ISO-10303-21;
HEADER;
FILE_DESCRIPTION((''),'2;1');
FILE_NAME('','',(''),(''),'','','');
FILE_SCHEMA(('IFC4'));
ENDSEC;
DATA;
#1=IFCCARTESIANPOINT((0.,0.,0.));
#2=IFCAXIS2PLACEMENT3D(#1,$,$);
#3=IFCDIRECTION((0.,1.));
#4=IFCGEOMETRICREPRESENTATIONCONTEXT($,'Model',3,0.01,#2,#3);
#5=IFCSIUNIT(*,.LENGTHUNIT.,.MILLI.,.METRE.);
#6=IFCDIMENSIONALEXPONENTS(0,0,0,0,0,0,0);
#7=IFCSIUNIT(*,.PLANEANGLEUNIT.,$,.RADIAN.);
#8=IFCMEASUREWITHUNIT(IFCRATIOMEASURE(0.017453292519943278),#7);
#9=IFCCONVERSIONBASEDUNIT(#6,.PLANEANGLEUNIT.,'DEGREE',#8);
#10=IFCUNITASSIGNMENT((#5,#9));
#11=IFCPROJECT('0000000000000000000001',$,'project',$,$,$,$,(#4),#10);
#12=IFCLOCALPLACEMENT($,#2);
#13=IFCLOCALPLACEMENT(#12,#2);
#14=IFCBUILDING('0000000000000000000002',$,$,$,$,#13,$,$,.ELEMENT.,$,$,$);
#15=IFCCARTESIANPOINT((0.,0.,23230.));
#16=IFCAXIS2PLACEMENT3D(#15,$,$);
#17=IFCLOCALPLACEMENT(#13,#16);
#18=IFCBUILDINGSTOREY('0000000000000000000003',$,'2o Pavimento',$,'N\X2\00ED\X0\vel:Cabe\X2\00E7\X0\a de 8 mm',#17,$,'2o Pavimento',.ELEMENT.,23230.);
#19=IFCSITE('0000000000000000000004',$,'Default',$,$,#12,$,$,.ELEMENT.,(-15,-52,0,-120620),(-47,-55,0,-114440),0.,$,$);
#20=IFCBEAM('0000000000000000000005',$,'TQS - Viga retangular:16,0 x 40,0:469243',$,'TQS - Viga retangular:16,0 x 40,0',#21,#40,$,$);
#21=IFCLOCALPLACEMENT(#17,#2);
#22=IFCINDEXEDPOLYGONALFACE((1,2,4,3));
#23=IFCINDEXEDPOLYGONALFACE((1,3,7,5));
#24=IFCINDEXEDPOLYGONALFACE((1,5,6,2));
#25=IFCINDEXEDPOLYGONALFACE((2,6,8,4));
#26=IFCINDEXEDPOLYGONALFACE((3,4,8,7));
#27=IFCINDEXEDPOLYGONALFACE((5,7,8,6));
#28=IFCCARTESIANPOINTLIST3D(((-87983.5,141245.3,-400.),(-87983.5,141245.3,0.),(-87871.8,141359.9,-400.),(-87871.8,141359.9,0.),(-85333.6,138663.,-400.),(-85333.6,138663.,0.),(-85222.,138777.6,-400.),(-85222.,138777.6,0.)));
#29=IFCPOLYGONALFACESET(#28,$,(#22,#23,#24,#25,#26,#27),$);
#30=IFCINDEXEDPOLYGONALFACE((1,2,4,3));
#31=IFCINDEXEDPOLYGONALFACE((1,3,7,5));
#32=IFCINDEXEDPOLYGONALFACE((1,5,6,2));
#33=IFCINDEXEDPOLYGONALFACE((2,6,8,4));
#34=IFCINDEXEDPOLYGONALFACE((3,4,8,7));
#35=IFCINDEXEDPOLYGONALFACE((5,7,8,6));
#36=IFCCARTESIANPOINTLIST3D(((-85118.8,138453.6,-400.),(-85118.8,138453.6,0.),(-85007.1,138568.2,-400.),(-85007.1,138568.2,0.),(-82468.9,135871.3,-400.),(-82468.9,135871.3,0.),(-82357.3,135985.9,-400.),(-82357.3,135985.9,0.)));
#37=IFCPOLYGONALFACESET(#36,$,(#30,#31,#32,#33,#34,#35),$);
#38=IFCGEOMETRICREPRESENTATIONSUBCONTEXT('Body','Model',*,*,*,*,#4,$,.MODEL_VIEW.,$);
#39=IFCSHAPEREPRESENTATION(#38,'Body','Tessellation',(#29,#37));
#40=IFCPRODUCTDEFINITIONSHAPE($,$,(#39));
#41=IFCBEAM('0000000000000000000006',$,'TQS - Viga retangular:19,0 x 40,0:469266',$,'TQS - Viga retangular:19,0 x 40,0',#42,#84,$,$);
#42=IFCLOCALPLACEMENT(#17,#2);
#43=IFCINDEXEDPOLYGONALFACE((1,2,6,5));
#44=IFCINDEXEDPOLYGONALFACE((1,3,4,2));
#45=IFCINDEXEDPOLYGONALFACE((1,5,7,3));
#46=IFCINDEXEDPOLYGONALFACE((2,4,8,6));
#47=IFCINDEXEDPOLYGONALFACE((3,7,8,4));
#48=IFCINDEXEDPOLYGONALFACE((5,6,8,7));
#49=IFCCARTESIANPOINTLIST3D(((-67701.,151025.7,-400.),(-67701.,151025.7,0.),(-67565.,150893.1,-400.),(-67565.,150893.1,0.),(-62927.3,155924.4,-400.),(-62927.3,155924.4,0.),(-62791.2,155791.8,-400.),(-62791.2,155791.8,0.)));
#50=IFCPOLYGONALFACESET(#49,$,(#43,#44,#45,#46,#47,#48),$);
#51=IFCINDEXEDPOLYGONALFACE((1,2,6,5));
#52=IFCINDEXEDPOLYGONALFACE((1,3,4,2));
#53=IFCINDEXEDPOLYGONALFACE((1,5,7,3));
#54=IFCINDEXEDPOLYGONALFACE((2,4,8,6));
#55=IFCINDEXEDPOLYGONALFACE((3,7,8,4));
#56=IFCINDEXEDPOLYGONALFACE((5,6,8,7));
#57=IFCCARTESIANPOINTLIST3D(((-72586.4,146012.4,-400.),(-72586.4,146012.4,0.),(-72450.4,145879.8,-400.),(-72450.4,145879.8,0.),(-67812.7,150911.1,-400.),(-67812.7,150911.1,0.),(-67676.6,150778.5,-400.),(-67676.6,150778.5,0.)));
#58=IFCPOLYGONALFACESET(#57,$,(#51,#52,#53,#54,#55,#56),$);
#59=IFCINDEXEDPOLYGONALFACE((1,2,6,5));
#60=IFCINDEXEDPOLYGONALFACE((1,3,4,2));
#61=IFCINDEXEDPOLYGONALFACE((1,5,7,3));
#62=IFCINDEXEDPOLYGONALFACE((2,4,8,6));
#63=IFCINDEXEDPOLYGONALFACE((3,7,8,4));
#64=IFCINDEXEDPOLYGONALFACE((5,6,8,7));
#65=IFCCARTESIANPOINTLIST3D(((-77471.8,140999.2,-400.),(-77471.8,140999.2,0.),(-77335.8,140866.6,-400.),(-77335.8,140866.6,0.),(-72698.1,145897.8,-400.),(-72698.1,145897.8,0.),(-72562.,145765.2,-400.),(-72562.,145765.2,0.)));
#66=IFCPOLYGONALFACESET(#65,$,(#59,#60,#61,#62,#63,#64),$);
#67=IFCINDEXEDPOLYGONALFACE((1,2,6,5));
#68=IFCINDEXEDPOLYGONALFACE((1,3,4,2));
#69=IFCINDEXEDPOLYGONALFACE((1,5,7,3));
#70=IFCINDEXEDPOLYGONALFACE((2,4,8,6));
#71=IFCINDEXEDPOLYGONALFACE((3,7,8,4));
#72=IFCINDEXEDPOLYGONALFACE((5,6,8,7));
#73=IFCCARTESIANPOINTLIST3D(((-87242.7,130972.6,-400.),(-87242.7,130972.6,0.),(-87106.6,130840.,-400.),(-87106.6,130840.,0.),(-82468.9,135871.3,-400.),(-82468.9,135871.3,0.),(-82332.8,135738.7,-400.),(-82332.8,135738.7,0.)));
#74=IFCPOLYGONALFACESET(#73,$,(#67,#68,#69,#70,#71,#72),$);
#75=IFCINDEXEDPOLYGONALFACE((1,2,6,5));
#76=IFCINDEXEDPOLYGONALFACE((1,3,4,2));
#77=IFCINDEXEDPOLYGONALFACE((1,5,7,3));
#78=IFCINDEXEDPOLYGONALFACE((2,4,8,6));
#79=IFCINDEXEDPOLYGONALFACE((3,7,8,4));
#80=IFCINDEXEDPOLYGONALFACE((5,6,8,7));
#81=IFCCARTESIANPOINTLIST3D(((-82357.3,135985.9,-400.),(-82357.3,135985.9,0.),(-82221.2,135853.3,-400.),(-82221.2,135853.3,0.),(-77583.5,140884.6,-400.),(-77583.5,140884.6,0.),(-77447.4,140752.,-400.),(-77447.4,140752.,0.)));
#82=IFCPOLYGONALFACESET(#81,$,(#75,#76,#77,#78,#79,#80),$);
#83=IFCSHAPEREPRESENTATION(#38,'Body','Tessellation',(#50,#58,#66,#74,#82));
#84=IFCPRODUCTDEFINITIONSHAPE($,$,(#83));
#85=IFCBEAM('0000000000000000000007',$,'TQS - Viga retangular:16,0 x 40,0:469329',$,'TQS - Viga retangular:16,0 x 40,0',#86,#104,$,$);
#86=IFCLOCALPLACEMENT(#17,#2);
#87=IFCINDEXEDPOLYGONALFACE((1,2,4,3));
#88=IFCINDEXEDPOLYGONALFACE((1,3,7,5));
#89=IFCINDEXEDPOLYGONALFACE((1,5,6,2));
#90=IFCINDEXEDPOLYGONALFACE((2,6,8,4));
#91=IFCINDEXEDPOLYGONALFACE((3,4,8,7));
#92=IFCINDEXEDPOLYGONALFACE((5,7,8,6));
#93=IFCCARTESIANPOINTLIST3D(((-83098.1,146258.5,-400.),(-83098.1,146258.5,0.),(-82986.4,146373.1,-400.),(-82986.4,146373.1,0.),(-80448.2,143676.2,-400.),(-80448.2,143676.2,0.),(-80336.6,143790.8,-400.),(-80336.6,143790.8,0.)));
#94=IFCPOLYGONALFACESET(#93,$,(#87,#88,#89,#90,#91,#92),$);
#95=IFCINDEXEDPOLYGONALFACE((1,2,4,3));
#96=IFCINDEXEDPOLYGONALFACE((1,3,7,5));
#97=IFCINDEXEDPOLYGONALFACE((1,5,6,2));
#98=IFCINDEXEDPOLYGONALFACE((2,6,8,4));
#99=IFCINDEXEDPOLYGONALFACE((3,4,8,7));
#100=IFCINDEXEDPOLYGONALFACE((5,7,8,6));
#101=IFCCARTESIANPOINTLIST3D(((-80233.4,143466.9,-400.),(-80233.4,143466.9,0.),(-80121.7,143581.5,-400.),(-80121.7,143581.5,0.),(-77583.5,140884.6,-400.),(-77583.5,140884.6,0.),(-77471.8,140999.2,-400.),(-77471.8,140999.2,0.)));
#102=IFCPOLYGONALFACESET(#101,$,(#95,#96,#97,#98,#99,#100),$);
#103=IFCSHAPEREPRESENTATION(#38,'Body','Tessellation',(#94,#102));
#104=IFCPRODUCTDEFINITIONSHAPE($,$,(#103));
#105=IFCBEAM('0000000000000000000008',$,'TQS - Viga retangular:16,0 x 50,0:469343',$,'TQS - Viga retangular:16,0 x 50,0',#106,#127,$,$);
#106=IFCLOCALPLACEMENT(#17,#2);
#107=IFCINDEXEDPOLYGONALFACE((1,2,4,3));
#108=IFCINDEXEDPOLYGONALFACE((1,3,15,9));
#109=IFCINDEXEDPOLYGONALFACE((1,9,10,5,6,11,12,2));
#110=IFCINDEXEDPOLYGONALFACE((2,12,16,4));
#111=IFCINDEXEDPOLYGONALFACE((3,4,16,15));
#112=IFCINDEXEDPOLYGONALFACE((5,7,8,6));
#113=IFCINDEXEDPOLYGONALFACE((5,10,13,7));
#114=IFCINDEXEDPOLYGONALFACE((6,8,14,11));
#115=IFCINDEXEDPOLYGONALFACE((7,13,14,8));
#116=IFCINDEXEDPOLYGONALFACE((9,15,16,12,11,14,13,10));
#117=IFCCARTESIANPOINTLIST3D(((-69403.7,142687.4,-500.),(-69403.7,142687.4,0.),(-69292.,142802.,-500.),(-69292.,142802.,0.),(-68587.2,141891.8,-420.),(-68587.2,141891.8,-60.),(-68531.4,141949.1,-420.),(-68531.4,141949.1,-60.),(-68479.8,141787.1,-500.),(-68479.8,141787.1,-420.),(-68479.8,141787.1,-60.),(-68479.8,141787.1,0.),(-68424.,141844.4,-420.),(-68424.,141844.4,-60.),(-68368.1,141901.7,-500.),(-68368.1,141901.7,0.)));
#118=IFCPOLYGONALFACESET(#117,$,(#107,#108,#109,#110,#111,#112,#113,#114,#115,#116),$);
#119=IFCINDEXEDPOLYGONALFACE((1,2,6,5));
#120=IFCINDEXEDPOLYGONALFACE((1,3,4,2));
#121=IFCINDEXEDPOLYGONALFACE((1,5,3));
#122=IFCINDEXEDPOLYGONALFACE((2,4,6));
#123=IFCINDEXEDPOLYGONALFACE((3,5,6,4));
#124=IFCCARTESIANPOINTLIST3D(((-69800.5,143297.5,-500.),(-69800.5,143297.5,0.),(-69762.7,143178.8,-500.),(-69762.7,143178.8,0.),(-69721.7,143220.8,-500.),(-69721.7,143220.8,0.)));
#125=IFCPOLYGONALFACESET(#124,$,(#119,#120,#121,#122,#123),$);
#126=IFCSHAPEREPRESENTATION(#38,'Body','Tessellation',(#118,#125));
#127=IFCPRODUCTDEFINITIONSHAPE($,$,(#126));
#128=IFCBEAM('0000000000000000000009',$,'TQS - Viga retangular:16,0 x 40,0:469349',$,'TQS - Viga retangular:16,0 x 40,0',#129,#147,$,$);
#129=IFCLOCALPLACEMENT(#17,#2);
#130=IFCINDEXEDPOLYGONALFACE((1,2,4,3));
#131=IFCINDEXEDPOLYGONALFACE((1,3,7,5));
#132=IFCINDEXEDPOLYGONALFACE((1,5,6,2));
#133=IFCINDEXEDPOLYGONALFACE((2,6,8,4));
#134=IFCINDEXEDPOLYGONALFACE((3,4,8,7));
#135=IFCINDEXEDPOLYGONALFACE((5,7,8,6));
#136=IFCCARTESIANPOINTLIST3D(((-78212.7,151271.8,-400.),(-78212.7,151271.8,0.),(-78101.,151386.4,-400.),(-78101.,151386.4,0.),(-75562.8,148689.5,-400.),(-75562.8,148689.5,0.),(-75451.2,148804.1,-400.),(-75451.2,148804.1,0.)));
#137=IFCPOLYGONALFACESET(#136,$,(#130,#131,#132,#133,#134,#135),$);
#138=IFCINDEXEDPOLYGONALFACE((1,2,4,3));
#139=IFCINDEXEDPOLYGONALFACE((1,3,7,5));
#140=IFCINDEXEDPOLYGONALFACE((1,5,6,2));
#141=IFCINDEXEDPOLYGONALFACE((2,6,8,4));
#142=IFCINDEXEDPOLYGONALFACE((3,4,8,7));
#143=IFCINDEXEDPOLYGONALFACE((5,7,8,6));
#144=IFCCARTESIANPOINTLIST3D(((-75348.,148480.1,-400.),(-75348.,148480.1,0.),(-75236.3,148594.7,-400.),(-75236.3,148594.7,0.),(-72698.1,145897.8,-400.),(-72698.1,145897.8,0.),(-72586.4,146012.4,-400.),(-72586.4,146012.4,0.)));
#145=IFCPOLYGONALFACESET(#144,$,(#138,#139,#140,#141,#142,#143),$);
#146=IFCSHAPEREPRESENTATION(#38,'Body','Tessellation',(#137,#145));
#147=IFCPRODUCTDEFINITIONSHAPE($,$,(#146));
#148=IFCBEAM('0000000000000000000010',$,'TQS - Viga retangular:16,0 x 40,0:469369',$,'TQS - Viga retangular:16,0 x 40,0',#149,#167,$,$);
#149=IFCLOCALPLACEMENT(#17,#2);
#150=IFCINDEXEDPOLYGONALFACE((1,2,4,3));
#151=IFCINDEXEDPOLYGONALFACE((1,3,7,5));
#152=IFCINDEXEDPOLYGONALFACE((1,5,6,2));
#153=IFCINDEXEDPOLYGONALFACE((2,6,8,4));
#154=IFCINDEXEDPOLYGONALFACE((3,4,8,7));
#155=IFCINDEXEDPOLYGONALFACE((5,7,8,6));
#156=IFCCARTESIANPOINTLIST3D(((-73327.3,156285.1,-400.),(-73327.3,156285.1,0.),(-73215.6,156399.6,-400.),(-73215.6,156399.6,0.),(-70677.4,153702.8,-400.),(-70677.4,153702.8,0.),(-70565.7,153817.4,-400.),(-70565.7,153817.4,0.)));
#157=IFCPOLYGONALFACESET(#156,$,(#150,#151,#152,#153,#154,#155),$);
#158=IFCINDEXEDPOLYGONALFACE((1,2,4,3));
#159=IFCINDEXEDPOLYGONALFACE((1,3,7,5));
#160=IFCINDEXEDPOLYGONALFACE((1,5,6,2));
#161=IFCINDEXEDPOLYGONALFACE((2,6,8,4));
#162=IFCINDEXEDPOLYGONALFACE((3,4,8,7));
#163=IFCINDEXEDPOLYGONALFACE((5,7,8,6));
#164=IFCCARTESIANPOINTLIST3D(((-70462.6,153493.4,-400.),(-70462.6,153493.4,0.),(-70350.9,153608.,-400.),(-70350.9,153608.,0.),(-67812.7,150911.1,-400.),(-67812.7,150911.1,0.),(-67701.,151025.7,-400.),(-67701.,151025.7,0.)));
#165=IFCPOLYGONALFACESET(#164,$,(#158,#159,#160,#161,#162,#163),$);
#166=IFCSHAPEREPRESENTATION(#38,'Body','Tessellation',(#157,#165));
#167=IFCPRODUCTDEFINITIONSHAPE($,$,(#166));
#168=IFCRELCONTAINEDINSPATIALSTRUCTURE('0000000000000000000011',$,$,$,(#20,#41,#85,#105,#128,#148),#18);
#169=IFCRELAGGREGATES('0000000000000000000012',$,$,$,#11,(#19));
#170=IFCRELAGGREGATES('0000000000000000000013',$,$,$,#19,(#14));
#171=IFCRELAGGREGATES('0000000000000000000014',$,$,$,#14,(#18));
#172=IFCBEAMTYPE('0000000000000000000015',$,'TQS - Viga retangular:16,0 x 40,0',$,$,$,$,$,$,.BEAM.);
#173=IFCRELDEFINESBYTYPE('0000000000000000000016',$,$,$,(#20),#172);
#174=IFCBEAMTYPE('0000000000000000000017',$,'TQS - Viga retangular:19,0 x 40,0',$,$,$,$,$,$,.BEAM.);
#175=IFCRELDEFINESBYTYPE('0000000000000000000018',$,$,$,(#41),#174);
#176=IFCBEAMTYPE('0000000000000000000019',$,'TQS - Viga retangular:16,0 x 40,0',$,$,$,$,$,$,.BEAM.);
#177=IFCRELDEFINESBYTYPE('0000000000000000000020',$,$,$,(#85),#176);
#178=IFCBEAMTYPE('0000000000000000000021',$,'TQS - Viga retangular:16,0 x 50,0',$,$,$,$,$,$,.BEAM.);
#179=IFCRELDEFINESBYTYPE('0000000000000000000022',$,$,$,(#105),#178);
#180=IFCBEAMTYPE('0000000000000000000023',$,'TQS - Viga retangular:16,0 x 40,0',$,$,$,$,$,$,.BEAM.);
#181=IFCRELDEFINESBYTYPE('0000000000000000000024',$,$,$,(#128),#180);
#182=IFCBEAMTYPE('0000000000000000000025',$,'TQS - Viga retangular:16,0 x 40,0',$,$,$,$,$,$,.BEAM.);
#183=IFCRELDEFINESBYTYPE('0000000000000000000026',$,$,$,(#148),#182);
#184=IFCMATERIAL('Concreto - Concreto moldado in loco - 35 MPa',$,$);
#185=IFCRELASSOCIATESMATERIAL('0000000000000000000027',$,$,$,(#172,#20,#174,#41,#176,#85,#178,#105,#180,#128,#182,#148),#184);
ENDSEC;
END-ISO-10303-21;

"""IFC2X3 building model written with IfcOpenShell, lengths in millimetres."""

from ifc_helpers import new_model, entity, si_unit, converted_unit, direction, frame, frame_2d, origin, place, context, subcontext, project, spatial, polyline, rectangle, extrude, boolean, clip, halfspace, bounded_halfspace, source, transform, mapped, material, type_object, type_shapes, element, save


model = new_model("IFC2X3")

# Units and contexts
model_context = context("Model", 3, precision=0.01, world=origin(), true_north=direction((0.0, 1.0)))
body_context = subcontext(model_context, "Body", "Model", "MODEL_VIEW")
ifc_project = project(units=[si_unit("LENGTHUNIT", "METRE", prefix="MILLI"), converted_unit("PLANEANGLEUNIT", "DEGREE", entity("IfcRatioMeasure", 0.017453292519943278), si_unit("PLANEANGLEUNIT", "RADIAN"), dimensions=[0, 0, 0, 0, 0, 0, 0])], contexts=[model_context])

# Site, building, storey
site_placement = place(None, origin())
site = spatial("IfcSite", under=ifc_project, at=site_placement, Name="Default", CompositionType="ELEMENT", RefLatitude=(-15, -52, 0, -120620), RefLongitude=(-47, -55, 0, -114440), RefElevation=0.0)
building_placement = place(site_placement, origin())
building = spatial("IfcBuilding", under=site, at=building_placement, CompositionType="ELEMENT")
storey_placement = place(building_placement, frame((0.0, 0.0, 23230.0)))
storey = spatial("IfcBuildingStorey", under=building, at=storey_placement, Name="2o Pavimento", ObjectType="Nível:Cabeça de 8 mm", LongName="2o Pavimento", CompositionType="ELEMENT", Elevation=23230.0)

# Beams
ifc_material = material(Name="Concreto - Concreto moldado in loco - 35 MPa")
beam_type_1 = type_object("IfcBeamType", Name="TQS - Viga retangular:16,0 x 40,0", PredefinedType="BEAM", material=ifc_material)
shared_shape_1 = source(origin(), body_context, "Body", "SweptSolid", [
    extrude(rectangle(XDim=400.0, YDim=160.0, at=frame_2d((0.0, 0.0), x_axis=(1.0, 0.0))), frame((-85277.8, 138720.3, 23030.0), z_axis=(-0.71618, 0.697915, 0.0), x_axis=(0.0, 0.0, 1.0)), (0.0, 0.0, 1.0), 3700.0),
    extrude(rectangle(XDim=400.0, YDim=160.0, at=frame_2d((0.0, 0.0), x_axis=(1.0, 0.0))), frame((-82413.1, 135928.6, 23030.0), z_axis=(-0.71618, 0.697915, 0.0), x_axis=(0.0, 0.0, 1.0)), (0.0, 0.0, 1.0), 3700.0),
])
type_shapes(beam_type_1, [shared_shape_1])
beam_1_placement = place(storey_placement, frame((0.0, 0.0, -23230.0)))
element("IfcBeam", 1, at=beam_1_placement, inside=storey, type_object=beam_type_1, material=ifc_material, Name="TQS - Viga retangular:16,0 x 40,0:469243", ObjectType="TQS - Viga retangular:16,0 x 40,0", context=body_context, shape_type="MappedRepresentation", body=[
    mapped(shared_shape_1, transform((0.0, 0.0, 0.0), scale=1.0)),
])
beam_type_2 = type_object("IfcBeamType", Name="TQS - Viga retangular:19,0 x 40,0", PredefinedType="BEAM", material=ifc_material)
shared_shape_2 = source(origin(), body_context, "Body", "SweptSolid", [
    extrude(rectangle(XDim=400.0, YDim=190.0, at=frame_2d((0.0, 0.0), x_axis=(1.0, 0.0))), frame((-67633.0, 150959.4, 23030.0), z_axis=(0.697915, 0.71618, 0.0), x_axis=(0.0, 0.0, 1.0)), (0.0, 0.0, 1.0), 6840.0),
    extrude(rectangle(XDim=400.0, YDim=190.0, at=frame_2d((0.0, 0.0), x_axis=(1.0, 0.0))), frame((-72518.4, 145946.1, 23030.0), z_axis=(0.697915, 0.71618, 0.0), x_axis=(0.0, 0.0, 1.0)), (0.0, 0.0, 1.0), 6840.0),
    extrude(rectangle(XDim=400.0, YDim=190.0, at=frame_2d((0.0, 0.0), x_axis=(1.0, 0.0))), frame((-77403.8, 140932.9, 23030.0), z_axis=(0.697915, 0.71618, 0.0), x_axis=(0.0, 0.0, 1.0)), (0.0, 0.0, 1.0), 6840.0),
    extrude(rectangle(XDim=400.0, YDim=190.0, at=frame_2d((0.0, 0.0), x_axis=(1.0, 0.0))), frame((-87174.6, 130906.3, 23030.0), z_axis=(0.697915, 0.71618, 0.0), x_axis=(0.0, 0.0, 1.0)), (0.0, 0.0, 1.0), 6840.0),
    extrude(rectangle(XDim=400.0, YDim=190.0, at=frame_2d((0.0, 0.0), x_axis=(1.0, 0.0))), frame((-82289.2, 135919.6, 23030.0), z_axis=(0.697915, 0.71618, 0.0), x_axis=(0.0, 0.0, 1.0)), (0.0, 0.0, 1.0), 6840.0),
])
type_shapes(beam_type_2, [shared_shape_2])
beam_2_placement = place(storey_placement, frame((0.0, 0.0, -23230.0)))
element("IfcBeam", 2, at=beam_2_placement, inside=storey, type_object=beam_type_2, material=ifc_material, Name="TQS - Viga retangular:19,0 x 40,0:469266", ObjectType="TQS - Viga retangular:19,0 x 40,0", context=body_context, shape_type="MappedRepresentation", body=[
    mapped(shared_shape_2, transform((0.0, 0.0, 0.0), scale=1.0)),
])
beam_type_3 = type_object("IfcBeamType", Name="TQS - Viga retangular:16,0 x 40,0", PredefinedType="BEAM", material=ifc_material)
shared_shape_3 = source(origin(), body_context, "Body", "SweptSolid", [
    extrude(rectangle(XDim=400.0, YDim=160.0, at=frame_2d((0.0, 0.0), x_axis=(1.0, 0.0))), frame((-80392.4, 143733.5, 23030.0), z_axis=(-0.71618, 0.697915, 0.0), x_axis=(0.0, 0.0, 1.0)), (0.0, 0.0, 1.0), 3700.0),
    extrude(rectangle(XDim=400.0, YDim=160.0, at=frame_2d((0.0, 0.0), x_axis=(1.0, 0.0))), frame((-77527.7, 140941.9, 23030.0), z_axis=(-0.71618, 0.697915, 0.0), x_axis=(0.0, 0.0, 1.0)), (0.0, 0.0, 1.0), 3700.0),
])
type_shapes(beam_type_3, [shared_shape_3])
beam_3_placement = place(storey_placement, frame((0.0, 0.0, -23230.0)))
element("IfcBeam", 3, at=beam_3_placement, inside=storey, type_object=beam_type_3, material=ifc_material, Name="TQS - Viga retangular:16,0 x 40,0:469329", ObjectType="TQS - Viga retangular:16,0 x 40,0", context=body_context, shape_type="MappedRepresentation", body=[
    mapped(shared_shape_3, transform((0.0, 0.0, 0.0), scale=1.0)),
])
beam_type_4 = type_object("IfcBeamType", Name="TQS - Viga retangular:16,0 x 50,0", PredefinedType="BEAM", material=ifc_material)
shared_shape_4 = source(origin(), body_context, "Body", "SweptSolid", [
    boolean("DIFFERENCE", clip(extrude(rectangle(XDim=500.0, YDim=160.0, at=frame_2d((0.0, 0.0), x_axis=(0.0, 1.0))), frame((-68424.0, 141844.4, 22980.0), z_axis=(-0.71618, 0.697915, 0.0), x_axis=(0.697915, 0.71618, 0.0)), (0.0, 0.0, 1.0), 1290.0), bounded_halfspace(frame((-68531.4, 141949.1, 22810.0), z_axis=(0.71618, -0.697915, 0.0), x_axis=(-0.697915, -0.71618, 0.0)), False, frame((-68424.0, 141844.4, 22980.0), z_axis=(-0.71618, 0.697915, 0.0), x_axis=(0.697915, 0.71618, 0.0)), polyline([(0.0, 170.0), (0.0, -190.0), (-80.0, -190.0), (-80.0, -90.0), (-80.0, 170.0), (0.0, 170.0)]))), extrude(rectangle(XDim=360.0, YDim=80.0, at=frame_2d((0.0, 0.0), x_axis=(0.0, 1.0))), frame((-68451.9, 141815.8, 22990.0), z_axis=(0.71618, -0.697915, 0.0), x_axis=(0.697915, 0.71618, 0.0)), (0.0, 0.0, -1.0), 150.0)),
    clip(extrude(rectangle(XDim=500.0, YDim=58.7, at=frame_2d((0.0, 0.0), x_axis=(0.0, 1.0))), frame((-69742.2, 143199.8, 22980.0), z_axis=(-0.71618, 0.697915, 0.0), x_axis=(0.697915, 0.71618, 0.0)), (0.0, 0.0, 1.0), 110.0), halfspace(frame((-69697.3, 142973.6, 23230.0), z_axis=(-0.952834, -0.303493, 0.0), x_axis=(0.303493, -0.952834, 0.0)), False)),
])
type_shapes(beam_type_4, [shared_shape_4])
beam_4_placement = place(storey_placement, frame((0.0, 0.0, -23230.0)))
element("IfcBeam", 4, at=beam_4_placement, inside=storey, type_object=beam_type_4, material=ifc_material, Name="TQS - Viga retangular:16,0 x 50,0:469343", ObjectType="TQS - Viga retangular:16,0 x 50,0", context=body_context, shape_type="MappedRepresentation", body=[
    mapped(shared_shape_4, transform((0.0, 0.0, 0.0), scale=1.0)),
])
beam_type_5 = type_object("IfcBeamType", Name="TQS - Viga retangular:16,0 x 40,0", PredefinedType="BEAM", material=ifc_material)
shared_shape_5 = source(origin(), body_context, "Body", "SweptSolid", [
    extrude(rectangle(XDim=400.0, YDim=160.0, at=frame_2d((0.0, 0.0), x_axis=(1.0, 0.0))), frame((-75507.0, 148746.8, 23030.0), z_axis=(-0.71618, 0.697915, 0.0), x_axis=(0.0, 0.0, 1.0)), (0.0, 0.0, 1.0), 3700.0),
    extrude(rectangle(XDim=400.0, YDim=160.0, at=frame_2d((0.0, 0.0), x_axis=(1.0, 0.0))), frame((-72642.3, 145955.1, 23030.0), z_axis=(-0.71618, 0.697915, 0.0), x_axis=(0.0, 0.0, 1.0)), (0.0, 0.0, 1.0), 3700.0),
])
type_shapes(beam_type_5, [shared_shape_5])
beam_5_placement = place(storey_placement, frame((0.0, 0.0, -23230.0)))
element("IfcBeam", 5, at=beam_5_placement, inside=storey, type_object=beam_type_5, material=ifc_material, Name="TQS - Viga retangular:16,0 x 40,0:469349", ObjectType="TQS - Viga retangular:16,0 x 40,0", context=body_context, shape_type="MappedRepresentation", body=[
    mapped(shared_shape_5, transform((0.0, 0.0, 0.0), scale=1.0)),
])
beam_type_6 = type_object("IfcBeamType", Name="TQS - Viga retangular:16,0 x 40,0", PredefinedType="BEAM", material=ifc_material)
shared_shape_6 = source(origin(), body_context, "Body", "SweptSolid", [
    extrude(rectangle(XDim=400.0, YDim=160.0, at=frame_2d((0.0, 0.0), x_axis=(1.0, 0.0))), frame((-70621.6, 153760.1, 23030.0), z_axis=(-0.71618, 0.697915, 0.0), x_axis=(0.0, 0.0, 1.0)), (0.0, 0.0, 1.0), 3700.0),
    extrude(rectangle(XDim=400.0, YDim=160.0, at=frame_2d((0.0, 0.0), x_axis=(1.0, 0.0))), frame((-67756.9, 150968.4, 23030.0), z_axis=(-0.71618, 0.697915, 0.0), x_axis=(0.0, 0.0, 1.0)), (0.0, 0.0, 1.0), 3700.0),
])
type_shapes(beam_type_6, [shared_shape_6])
beam_6_placement = place(storey_placement, frame((0.0, 0.0, -23230.0)))
element("IfcBeam", 6, at=beam_6_placement, inside=storey, type_object=beam_type_6, material=ifc_material, Name="TQS - Viga retangular:16,0 x 40,0:469369", ObjectType="TQS - Viga retangular:16,0 x 40,0", context=body_context, shape_type="MappedRepresentation", body=[
    mapped(shared_shape_6, transform((0.0, 0.0, 0.0), scale=1.0)),
])

save(model, "model.ifc")
